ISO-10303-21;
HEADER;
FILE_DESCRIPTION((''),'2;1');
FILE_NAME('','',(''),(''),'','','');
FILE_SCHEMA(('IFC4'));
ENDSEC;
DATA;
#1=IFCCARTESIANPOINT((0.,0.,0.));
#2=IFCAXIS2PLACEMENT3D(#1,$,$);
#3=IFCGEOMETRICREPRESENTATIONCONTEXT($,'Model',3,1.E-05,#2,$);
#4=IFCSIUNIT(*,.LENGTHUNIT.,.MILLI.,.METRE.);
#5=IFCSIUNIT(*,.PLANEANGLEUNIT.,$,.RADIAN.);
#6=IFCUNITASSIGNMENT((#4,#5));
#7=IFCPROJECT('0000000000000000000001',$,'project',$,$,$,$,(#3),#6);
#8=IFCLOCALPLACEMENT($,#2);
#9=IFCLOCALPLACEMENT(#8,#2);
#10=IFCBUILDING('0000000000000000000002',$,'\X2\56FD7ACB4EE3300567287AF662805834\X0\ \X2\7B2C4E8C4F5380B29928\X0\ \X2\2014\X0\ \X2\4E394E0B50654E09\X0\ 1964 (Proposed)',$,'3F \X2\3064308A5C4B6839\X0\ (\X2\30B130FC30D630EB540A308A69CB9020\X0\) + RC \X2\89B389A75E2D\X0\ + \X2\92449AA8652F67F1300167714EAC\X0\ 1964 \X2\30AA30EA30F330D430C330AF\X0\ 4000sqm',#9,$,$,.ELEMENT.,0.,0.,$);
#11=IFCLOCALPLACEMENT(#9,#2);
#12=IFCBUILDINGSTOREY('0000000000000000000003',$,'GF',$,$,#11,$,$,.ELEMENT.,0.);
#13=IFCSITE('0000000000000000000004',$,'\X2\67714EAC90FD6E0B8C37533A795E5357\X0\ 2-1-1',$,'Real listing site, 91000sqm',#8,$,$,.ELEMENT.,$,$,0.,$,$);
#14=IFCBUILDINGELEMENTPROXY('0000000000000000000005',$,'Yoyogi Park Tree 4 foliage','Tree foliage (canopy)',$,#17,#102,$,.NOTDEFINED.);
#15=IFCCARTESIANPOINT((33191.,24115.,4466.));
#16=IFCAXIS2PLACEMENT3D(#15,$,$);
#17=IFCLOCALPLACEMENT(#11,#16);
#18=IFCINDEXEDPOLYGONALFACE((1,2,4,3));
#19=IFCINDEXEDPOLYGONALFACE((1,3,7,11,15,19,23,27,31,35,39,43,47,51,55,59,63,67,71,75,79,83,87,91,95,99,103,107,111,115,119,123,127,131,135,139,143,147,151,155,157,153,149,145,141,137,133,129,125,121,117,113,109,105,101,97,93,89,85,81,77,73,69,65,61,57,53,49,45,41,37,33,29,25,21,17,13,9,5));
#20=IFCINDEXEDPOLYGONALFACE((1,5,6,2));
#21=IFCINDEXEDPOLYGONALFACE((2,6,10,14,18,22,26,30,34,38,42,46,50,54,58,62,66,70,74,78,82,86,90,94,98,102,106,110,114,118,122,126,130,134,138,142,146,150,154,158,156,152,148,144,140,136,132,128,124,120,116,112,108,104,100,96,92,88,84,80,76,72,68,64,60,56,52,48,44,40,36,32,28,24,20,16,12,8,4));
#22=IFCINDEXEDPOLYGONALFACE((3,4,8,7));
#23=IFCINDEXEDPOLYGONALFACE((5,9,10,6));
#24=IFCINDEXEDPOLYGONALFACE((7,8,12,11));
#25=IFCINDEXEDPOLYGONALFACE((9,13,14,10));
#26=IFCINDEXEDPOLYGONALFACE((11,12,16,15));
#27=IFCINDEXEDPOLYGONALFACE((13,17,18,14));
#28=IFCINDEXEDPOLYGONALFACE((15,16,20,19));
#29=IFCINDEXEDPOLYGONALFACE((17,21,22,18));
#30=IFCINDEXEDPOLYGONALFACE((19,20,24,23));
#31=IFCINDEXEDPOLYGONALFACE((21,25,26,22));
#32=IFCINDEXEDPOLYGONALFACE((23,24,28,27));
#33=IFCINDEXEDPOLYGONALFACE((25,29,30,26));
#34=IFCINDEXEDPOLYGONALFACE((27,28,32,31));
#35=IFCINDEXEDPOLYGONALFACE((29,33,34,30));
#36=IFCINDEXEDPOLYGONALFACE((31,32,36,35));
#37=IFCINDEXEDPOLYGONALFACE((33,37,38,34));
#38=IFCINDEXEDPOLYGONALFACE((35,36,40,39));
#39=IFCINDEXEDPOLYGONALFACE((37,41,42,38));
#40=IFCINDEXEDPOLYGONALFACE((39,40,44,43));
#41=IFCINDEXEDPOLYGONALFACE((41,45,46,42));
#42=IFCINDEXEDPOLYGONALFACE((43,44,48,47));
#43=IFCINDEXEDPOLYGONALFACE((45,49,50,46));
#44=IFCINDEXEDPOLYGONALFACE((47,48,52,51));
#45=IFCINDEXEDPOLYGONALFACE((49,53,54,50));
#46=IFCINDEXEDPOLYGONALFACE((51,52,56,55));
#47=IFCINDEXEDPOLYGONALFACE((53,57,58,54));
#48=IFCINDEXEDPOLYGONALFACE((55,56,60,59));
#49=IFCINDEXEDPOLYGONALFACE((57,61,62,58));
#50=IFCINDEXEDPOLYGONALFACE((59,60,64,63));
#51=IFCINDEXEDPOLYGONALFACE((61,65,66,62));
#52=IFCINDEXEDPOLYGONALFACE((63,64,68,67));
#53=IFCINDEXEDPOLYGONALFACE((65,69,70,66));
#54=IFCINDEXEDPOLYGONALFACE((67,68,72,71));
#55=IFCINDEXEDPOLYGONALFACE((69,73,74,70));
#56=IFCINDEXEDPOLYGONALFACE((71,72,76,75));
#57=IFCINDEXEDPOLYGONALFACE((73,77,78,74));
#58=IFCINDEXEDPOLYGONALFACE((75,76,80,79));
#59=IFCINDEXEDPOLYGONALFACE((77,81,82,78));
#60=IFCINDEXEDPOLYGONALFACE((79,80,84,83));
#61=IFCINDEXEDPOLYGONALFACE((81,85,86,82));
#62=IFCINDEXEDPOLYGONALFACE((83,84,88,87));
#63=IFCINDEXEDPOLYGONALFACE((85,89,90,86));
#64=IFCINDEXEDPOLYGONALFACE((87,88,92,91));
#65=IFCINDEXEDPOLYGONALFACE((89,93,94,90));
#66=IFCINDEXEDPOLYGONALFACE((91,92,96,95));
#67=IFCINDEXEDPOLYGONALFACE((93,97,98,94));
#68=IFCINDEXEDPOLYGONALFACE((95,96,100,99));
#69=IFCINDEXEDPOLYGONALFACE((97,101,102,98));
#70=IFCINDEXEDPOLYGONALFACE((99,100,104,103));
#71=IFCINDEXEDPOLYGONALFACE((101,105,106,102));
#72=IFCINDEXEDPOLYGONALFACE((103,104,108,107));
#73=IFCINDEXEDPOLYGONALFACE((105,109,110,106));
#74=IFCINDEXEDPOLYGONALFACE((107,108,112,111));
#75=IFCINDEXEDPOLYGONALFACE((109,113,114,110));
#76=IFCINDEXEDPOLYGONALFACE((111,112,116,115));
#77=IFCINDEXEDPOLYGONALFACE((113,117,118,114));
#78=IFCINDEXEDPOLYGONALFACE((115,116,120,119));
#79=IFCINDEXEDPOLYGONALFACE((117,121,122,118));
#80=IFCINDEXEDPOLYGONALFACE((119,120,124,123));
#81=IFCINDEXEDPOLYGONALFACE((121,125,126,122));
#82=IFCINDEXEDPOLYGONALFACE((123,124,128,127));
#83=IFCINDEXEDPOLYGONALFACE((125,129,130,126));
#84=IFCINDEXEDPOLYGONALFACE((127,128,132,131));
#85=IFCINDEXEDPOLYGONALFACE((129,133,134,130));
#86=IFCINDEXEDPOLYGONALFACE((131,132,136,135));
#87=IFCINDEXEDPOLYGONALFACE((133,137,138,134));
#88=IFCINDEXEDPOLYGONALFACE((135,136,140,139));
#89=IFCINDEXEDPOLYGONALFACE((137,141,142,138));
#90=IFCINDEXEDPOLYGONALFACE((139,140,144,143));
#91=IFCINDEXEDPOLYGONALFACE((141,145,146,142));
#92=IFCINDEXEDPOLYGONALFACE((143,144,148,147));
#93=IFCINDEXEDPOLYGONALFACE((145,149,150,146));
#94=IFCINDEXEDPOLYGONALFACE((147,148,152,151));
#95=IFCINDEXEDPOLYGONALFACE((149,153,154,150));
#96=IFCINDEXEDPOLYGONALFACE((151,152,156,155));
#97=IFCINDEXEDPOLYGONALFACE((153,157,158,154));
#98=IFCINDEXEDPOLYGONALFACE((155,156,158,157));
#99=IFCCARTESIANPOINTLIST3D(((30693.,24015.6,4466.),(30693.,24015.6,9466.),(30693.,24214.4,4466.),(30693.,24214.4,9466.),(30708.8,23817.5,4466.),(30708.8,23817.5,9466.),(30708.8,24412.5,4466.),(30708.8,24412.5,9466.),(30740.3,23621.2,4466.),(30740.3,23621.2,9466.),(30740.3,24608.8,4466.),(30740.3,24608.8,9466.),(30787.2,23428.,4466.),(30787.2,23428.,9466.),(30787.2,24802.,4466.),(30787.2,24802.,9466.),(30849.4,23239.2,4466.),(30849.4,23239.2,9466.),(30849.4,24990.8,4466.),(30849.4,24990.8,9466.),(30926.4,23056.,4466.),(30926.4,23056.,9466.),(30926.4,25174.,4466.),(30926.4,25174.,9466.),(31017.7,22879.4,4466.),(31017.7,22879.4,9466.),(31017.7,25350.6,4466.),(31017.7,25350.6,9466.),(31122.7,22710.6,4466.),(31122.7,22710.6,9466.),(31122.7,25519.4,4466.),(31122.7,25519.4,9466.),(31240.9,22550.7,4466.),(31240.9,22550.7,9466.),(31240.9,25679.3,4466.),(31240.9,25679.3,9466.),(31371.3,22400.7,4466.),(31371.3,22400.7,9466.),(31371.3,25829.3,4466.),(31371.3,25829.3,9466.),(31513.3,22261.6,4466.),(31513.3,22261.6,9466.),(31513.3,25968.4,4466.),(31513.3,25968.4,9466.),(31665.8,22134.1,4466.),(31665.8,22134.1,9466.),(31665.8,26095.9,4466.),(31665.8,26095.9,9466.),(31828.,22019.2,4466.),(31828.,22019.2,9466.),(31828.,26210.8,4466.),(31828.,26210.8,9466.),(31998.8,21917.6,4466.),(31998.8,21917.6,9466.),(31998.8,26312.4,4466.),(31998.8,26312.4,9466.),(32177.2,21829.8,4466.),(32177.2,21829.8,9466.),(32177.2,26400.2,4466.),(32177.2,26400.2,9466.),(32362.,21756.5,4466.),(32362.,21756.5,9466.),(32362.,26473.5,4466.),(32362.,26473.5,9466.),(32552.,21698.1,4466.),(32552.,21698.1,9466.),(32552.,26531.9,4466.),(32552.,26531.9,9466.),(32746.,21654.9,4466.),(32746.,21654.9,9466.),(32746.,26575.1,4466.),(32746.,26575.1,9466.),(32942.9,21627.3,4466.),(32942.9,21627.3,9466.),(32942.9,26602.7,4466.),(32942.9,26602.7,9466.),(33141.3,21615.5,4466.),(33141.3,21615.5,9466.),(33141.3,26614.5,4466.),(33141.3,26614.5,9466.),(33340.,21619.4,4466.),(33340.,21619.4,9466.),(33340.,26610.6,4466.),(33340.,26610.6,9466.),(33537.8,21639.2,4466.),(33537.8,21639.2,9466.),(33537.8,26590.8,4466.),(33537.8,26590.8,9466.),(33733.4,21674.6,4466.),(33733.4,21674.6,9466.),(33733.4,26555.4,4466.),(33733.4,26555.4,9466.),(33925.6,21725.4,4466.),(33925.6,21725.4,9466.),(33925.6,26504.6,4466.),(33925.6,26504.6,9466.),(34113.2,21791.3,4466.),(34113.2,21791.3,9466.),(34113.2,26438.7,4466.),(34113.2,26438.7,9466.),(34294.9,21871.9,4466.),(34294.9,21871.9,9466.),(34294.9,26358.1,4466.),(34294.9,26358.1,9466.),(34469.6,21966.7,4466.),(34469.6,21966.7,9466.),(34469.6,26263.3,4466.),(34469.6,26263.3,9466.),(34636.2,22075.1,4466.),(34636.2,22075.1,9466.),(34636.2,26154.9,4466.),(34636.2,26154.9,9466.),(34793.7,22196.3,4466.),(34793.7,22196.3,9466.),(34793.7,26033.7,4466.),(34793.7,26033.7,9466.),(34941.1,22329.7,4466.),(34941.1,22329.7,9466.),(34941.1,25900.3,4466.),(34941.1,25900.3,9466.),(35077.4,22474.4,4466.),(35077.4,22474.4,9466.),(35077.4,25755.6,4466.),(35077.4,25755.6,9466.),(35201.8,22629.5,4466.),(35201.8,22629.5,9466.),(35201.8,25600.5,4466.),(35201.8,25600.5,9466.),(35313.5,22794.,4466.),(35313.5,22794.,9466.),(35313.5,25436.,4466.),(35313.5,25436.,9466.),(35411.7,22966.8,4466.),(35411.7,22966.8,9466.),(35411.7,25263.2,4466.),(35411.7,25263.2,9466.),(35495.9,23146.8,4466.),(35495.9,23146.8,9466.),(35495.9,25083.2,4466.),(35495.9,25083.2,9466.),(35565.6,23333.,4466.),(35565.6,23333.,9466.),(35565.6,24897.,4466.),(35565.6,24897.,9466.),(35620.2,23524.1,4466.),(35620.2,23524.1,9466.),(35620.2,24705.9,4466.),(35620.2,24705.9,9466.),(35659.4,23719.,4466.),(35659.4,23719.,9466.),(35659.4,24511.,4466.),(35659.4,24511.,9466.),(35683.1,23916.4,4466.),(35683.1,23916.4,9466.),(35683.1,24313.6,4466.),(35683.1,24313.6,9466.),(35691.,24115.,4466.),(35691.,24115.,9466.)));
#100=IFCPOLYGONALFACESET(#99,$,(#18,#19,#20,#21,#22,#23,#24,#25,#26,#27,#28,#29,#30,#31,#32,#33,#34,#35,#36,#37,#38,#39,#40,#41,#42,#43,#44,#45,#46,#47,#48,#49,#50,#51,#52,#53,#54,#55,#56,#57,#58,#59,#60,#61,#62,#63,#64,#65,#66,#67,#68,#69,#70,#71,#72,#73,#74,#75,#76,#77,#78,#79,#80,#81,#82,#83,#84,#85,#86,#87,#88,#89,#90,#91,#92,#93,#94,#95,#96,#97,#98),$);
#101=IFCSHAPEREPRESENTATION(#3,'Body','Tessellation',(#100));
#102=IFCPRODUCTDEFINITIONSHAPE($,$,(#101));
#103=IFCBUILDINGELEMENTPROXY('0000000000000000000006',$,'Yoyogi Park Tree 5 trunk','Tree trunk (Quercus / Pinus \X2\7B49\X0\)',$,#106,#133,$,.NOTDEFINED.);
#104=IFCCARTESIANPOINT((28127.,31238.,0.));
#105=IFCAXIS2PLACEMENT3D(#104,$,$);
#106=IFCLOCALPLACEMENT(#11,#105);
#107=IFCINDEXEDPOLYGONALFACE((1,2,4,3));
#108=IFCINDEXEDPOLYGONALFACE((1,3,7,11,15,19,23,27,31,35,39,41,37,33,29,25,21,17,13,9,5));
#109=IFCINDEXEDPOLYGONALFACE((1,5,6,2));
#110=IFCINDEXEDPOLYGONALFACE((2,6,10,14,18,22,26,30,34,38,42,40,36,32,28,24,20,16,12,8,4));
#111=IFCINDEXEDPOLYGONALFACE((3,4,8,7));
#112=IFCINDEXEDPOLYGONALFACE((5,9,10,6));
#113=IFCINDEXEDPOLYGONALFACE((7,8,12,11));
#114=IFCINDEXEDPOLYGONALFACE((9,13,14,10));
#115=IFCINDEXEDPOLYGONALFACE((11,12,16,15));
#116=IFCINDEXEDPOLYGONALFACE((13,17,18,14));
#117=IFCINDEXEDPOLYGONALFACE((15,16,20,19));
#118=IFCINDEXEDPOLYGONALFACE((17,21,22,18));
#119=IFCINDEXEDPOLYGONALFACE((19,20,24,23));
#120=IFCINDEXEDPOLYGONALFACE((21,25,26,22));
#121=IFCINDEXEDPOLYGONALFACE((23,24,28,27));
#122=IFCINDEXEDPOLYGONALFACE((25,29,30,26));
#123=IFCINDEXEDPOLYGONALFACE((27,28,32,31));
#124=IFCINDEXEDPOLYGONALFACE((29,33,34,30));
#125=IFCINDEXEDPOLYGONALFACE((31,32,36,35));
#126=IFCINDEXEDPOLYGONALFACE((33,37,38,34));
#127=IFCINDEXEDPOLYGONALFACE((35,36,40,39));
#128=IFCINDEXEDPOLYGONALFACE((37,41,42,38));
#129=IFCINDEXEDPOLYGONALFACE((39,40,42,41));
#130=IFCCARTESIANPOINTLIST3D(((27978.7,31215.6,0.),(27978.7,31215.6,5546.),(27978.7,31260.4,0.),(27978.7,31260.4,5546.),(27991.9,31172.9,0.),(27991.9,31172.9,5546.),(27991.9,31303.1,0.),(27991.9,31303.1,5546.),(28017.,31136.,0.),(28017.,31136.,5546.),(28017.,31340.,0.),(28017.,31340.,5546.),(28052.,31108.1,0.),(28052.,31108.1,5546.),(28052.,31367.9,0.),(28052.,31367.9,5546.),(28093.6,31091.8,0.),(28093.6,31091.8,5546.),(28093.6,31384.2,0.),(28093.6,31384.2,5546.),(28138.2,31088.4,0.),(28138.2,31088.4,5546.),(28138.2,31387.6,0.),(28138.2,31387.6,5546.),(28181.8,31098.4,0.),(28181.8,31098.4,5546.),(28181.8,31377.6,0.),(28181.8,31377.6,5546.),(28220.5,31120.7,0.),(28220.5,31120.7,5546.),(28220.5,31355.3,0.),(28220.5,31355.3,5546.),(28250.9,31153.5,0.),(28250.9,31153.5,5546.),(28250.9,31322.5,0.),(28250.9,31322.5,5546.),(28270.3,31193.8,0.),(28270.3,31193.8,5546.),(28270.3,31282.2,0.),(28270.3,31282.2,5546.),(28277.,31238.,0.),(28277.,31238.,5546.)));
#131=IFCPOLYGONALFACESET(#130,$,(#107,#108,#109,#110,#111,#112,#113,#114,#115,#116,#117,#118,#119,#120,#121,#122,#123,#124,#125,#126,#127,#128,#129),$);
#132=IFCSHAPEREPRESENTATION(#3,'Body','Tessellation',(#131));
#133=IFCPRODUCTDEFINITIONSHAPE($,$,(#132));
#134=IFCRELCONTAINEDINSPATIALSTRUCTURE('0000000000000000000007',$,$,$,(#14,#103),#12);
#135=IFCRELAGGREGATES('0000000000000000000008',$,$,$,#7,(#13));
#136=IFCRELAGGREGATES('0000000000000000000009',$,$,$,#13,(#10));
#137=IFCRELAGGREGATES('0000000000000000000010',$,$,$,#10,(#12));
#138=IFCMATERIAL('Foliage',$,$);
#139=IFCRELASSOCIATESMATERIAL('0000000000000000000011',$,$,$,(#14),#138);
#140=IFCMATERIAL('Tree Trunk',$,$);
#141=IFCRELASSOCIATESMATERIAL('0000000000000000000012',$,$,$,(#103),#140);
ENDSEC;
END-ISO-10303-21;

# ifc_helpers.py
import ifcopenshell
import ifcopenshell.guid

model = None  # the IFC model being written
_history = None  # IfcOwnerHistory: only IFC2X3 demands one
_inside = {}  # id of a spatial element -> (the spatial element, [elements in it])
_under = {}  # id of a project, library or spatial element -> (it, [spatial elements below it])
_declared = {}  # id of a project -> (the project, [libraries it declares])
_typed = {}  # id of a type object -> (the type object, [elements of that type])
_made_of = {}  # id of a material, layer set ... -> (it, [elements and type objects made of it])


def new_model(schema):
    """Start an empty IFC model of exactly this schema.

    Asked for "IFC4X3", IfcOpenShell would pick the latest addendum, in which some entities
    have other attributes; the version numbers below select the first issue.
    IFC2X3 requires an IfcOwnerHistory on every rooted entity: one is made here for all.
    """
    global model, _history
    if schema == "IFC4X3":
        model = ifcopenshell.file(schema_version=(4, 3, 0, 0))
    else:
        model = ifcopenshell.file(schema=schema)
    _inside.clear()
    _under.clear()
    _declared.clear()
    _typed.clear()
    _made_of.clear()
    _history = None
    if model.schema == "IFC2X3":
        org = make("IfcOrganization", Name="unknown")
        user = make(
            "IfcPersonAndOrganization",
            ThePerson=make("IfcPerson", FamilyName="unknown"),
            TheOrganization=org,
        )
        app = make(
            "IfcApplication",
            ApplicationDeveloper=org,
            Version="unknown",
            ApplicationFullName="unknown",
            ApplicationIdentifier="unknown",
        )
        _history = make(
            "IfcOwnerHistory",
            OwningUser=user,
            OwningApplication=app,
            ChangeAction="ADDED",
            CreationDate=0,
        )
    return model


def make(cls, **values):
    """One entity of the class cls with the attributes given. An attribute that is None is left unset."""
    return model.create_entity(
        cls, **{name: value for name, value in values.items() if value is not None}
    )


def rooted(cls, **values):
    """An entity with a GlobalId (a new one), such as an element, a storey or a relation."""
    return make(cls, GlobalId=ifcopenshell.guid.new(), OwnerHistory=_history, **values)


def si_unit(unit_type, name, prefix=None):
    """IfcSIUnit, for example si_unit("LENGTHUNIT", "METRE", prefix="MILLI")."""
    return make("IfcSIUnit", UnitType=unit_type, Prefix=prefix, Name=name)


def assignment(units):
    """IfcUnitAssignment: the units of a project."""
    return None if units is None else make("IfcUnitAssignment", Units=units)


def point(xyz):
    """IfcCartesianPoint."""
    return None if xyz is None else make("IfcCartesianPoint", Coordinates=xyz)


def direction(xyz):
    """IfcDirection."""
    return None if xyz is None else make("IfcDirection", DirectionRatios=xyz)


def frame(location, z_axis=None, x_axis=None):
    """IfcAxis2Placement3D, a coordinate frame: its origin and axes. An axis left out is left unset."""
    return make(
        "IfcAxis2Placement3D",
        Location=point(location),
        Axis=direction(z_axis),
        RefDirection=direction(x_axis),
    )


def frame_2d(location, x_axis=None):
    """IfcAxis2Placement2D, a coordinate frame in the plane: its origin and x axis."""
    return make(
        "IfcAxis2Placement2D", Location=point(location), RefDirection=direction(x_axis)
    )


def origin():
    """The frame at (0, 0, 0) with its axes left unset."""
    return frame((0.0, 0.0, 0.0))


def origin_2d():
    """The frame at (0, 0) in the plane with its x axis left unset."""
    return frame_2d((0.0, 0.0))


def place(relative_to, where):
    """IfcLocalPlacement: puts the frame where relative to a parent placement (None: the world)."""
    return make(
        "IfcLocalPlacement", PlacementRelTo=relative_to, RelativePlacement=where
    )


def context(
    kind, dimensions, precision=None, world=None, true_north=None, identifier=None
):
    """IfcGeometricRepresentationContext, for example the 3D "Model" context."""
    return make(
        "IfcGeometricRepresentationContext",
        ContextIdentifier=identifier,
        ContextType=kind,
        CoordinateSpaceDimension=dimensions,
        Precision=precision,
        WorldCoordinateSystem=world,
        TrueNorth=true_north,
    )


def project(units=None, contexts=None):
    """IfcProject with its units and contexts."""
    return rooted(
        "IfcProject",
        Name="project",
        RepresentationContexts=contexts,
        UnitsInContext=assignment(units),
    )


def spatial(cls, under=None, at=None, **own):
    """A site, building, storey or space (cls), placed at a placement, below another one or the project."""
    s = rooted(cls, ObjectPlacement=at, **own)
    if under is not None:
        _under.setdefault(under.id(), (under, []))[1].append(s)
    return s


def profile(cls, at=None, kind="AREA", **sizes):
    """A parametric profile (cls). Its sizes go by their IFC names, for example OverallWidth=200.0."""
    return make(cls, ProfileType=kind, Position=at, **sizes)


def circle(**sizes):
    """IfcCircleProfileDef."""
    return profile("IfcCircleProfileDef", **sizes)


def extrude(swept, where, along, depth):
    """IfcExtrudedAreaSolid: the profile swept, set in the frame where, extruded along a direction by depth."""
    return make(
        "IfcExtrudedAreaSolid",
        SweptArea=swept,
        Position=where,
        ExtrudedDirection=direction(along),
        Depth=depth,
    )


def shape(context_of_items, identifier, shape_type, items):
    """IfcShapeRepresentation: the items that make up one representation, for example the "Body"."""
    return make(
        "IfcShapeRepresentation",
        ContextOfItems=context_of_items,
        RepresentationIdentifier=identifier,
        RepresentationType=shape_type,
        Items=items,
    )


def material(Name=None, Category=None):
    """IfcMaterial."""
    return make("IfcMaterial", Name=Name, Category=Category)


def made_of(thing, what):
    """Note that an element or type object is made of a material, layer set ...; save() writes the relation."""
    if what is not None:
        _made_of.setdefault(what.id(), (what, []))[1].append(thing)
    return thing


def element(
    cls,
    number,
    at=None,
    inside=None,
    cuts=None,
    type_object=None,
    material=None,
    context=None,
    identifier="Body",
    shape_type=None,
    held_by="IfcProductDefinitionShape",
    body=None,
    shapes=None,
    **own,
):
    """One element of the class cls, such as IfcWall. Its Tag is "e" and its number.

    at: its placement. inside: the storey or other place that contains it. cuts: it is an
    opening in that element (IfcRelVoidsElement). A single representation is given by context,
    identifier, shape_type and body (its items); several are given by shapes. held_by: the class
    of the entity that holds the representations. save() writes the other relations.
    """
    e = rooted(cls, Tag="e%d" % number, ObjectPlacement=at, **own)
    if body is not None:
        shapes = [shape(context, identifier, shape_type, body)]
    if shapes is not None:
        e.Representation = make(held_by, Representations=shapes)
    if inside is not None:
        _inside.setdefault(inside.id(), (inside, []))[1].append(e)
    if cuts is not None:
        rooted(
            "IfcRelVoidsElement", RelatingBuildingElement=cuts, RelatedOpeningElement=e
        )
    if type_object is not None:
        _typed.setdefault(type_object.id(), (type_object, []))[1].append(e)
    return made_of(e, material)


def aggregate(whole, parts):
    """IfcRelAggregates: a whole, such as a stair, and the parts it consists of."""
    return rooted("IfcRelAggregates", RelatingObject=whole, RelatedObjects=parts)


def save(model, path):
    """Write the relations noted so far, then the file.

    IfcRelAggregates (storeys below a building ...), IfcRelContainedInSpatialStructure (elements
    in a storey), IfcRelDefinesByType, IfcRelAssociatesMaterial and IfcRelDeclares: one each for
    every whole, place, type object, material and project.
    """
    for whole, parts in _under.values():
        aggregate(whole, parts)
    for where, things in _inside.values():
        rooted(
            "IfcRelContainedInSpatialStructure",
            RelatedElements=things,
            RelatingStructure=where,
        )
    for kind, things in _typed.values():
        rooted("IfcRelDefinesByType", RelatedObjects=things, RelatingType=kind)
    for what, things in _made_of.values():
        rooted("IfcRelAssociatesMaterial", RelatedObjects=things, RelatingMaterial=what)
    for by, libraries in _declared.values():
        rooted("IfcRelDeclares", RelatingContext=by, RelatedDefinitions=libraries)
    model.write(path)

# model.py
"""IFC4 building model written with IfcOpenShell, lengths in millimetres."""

from ifc_helpers import new_model, si_unit, frame, origin, origin_2d, place, context, project, spatial, circle, extrude, material, element, save


model = new_model("IFC4")

# Units and contexts
model_context = context("Model", 3, precision=1e-05, world=origin())
ifc_project = project(units=[si_unit("LENGTHUNIT", "METRE", prefix="MILLI"), si_unit("PLANEANGLEUNIT", "RADIAN")], contexts=[model_context])

# Site, building, storey
site_placement = place(None, origin())
site = spatial("IfcSite", under=ifc_project, at=site_placement, Name="東京都渋谷区神南 2-1-1", ObjectType="Real listing site, 91000sqm", CompositionType="ELEMENT", RefElevation=0.0)
building_placement = place(site_placement, origin())
building = spatial("IfcBuilding", under=site, at=building_placement, Name="国立代々木競技場 第二体育館 — 丹下健三 1964 (Proposed)", ObjectType="3F つり屋根 (ケーブル吊り構造) + RC 観覧席 + 鉄骨支柱、東京 1964 オリンピック 4000sqm", CompositionType="ELEMENT", ElevationOfRefHeight=0.0, ElevationOfTerrain=0.0)
storey_placement = place(building_placement, origin())
storey = spatial("IfcBuildingStorey", under=building, at=storey_placement, Name="GF", CompositionType="ELEMENT", Elevation=0.0)

# Building element proxies
ifc_material_1 = material(Name="Tree Trunk")
ifc_material_2 = material(Name="Foliage")
proxy_1_placement = place(storey_placement, frame((33191.0, 24115.0, 4466.0)))
element("IfcBuildingElementProxy", 1, at=proxy_1_placement, inside=storey, material=ifc_material_2, Name="Yoyogi Park Tree 4 foliage", Description="Tree foliage (canopy)", PredefinedType="NOTDEFINED", context=model_context, shape_type="SweptSolid", body=[
    extrude(circle(Radius=2500.0, at=origin_2d()), frame((33191.0, 24115.0, 4466.0)), (0.0, 0.0, 1.0), 5000.0),
])
proxy_2_placement = place(storey_placement, frame((28127.0, 31238.0, 0.0)))
element("IfcBuildingElementProxy", 2, at=proxy_2_placement, inside=storey, material=ifc_material_1, Name="Yoyogi Park Tree 5 trunk", Description="Tree trunk (Quercus / Pinus 等)", PredefinedType="NOTDEFINED", context=model_context, shape_type="SweptSolid", body=[
    extrude(circle(Radius=150.0, at=origin_2d()), frame((28127.0, 31238.0, 0.0)), (0.0, 0.0, 1.0), 5546.0),
])

save(model, "model.ifc")
